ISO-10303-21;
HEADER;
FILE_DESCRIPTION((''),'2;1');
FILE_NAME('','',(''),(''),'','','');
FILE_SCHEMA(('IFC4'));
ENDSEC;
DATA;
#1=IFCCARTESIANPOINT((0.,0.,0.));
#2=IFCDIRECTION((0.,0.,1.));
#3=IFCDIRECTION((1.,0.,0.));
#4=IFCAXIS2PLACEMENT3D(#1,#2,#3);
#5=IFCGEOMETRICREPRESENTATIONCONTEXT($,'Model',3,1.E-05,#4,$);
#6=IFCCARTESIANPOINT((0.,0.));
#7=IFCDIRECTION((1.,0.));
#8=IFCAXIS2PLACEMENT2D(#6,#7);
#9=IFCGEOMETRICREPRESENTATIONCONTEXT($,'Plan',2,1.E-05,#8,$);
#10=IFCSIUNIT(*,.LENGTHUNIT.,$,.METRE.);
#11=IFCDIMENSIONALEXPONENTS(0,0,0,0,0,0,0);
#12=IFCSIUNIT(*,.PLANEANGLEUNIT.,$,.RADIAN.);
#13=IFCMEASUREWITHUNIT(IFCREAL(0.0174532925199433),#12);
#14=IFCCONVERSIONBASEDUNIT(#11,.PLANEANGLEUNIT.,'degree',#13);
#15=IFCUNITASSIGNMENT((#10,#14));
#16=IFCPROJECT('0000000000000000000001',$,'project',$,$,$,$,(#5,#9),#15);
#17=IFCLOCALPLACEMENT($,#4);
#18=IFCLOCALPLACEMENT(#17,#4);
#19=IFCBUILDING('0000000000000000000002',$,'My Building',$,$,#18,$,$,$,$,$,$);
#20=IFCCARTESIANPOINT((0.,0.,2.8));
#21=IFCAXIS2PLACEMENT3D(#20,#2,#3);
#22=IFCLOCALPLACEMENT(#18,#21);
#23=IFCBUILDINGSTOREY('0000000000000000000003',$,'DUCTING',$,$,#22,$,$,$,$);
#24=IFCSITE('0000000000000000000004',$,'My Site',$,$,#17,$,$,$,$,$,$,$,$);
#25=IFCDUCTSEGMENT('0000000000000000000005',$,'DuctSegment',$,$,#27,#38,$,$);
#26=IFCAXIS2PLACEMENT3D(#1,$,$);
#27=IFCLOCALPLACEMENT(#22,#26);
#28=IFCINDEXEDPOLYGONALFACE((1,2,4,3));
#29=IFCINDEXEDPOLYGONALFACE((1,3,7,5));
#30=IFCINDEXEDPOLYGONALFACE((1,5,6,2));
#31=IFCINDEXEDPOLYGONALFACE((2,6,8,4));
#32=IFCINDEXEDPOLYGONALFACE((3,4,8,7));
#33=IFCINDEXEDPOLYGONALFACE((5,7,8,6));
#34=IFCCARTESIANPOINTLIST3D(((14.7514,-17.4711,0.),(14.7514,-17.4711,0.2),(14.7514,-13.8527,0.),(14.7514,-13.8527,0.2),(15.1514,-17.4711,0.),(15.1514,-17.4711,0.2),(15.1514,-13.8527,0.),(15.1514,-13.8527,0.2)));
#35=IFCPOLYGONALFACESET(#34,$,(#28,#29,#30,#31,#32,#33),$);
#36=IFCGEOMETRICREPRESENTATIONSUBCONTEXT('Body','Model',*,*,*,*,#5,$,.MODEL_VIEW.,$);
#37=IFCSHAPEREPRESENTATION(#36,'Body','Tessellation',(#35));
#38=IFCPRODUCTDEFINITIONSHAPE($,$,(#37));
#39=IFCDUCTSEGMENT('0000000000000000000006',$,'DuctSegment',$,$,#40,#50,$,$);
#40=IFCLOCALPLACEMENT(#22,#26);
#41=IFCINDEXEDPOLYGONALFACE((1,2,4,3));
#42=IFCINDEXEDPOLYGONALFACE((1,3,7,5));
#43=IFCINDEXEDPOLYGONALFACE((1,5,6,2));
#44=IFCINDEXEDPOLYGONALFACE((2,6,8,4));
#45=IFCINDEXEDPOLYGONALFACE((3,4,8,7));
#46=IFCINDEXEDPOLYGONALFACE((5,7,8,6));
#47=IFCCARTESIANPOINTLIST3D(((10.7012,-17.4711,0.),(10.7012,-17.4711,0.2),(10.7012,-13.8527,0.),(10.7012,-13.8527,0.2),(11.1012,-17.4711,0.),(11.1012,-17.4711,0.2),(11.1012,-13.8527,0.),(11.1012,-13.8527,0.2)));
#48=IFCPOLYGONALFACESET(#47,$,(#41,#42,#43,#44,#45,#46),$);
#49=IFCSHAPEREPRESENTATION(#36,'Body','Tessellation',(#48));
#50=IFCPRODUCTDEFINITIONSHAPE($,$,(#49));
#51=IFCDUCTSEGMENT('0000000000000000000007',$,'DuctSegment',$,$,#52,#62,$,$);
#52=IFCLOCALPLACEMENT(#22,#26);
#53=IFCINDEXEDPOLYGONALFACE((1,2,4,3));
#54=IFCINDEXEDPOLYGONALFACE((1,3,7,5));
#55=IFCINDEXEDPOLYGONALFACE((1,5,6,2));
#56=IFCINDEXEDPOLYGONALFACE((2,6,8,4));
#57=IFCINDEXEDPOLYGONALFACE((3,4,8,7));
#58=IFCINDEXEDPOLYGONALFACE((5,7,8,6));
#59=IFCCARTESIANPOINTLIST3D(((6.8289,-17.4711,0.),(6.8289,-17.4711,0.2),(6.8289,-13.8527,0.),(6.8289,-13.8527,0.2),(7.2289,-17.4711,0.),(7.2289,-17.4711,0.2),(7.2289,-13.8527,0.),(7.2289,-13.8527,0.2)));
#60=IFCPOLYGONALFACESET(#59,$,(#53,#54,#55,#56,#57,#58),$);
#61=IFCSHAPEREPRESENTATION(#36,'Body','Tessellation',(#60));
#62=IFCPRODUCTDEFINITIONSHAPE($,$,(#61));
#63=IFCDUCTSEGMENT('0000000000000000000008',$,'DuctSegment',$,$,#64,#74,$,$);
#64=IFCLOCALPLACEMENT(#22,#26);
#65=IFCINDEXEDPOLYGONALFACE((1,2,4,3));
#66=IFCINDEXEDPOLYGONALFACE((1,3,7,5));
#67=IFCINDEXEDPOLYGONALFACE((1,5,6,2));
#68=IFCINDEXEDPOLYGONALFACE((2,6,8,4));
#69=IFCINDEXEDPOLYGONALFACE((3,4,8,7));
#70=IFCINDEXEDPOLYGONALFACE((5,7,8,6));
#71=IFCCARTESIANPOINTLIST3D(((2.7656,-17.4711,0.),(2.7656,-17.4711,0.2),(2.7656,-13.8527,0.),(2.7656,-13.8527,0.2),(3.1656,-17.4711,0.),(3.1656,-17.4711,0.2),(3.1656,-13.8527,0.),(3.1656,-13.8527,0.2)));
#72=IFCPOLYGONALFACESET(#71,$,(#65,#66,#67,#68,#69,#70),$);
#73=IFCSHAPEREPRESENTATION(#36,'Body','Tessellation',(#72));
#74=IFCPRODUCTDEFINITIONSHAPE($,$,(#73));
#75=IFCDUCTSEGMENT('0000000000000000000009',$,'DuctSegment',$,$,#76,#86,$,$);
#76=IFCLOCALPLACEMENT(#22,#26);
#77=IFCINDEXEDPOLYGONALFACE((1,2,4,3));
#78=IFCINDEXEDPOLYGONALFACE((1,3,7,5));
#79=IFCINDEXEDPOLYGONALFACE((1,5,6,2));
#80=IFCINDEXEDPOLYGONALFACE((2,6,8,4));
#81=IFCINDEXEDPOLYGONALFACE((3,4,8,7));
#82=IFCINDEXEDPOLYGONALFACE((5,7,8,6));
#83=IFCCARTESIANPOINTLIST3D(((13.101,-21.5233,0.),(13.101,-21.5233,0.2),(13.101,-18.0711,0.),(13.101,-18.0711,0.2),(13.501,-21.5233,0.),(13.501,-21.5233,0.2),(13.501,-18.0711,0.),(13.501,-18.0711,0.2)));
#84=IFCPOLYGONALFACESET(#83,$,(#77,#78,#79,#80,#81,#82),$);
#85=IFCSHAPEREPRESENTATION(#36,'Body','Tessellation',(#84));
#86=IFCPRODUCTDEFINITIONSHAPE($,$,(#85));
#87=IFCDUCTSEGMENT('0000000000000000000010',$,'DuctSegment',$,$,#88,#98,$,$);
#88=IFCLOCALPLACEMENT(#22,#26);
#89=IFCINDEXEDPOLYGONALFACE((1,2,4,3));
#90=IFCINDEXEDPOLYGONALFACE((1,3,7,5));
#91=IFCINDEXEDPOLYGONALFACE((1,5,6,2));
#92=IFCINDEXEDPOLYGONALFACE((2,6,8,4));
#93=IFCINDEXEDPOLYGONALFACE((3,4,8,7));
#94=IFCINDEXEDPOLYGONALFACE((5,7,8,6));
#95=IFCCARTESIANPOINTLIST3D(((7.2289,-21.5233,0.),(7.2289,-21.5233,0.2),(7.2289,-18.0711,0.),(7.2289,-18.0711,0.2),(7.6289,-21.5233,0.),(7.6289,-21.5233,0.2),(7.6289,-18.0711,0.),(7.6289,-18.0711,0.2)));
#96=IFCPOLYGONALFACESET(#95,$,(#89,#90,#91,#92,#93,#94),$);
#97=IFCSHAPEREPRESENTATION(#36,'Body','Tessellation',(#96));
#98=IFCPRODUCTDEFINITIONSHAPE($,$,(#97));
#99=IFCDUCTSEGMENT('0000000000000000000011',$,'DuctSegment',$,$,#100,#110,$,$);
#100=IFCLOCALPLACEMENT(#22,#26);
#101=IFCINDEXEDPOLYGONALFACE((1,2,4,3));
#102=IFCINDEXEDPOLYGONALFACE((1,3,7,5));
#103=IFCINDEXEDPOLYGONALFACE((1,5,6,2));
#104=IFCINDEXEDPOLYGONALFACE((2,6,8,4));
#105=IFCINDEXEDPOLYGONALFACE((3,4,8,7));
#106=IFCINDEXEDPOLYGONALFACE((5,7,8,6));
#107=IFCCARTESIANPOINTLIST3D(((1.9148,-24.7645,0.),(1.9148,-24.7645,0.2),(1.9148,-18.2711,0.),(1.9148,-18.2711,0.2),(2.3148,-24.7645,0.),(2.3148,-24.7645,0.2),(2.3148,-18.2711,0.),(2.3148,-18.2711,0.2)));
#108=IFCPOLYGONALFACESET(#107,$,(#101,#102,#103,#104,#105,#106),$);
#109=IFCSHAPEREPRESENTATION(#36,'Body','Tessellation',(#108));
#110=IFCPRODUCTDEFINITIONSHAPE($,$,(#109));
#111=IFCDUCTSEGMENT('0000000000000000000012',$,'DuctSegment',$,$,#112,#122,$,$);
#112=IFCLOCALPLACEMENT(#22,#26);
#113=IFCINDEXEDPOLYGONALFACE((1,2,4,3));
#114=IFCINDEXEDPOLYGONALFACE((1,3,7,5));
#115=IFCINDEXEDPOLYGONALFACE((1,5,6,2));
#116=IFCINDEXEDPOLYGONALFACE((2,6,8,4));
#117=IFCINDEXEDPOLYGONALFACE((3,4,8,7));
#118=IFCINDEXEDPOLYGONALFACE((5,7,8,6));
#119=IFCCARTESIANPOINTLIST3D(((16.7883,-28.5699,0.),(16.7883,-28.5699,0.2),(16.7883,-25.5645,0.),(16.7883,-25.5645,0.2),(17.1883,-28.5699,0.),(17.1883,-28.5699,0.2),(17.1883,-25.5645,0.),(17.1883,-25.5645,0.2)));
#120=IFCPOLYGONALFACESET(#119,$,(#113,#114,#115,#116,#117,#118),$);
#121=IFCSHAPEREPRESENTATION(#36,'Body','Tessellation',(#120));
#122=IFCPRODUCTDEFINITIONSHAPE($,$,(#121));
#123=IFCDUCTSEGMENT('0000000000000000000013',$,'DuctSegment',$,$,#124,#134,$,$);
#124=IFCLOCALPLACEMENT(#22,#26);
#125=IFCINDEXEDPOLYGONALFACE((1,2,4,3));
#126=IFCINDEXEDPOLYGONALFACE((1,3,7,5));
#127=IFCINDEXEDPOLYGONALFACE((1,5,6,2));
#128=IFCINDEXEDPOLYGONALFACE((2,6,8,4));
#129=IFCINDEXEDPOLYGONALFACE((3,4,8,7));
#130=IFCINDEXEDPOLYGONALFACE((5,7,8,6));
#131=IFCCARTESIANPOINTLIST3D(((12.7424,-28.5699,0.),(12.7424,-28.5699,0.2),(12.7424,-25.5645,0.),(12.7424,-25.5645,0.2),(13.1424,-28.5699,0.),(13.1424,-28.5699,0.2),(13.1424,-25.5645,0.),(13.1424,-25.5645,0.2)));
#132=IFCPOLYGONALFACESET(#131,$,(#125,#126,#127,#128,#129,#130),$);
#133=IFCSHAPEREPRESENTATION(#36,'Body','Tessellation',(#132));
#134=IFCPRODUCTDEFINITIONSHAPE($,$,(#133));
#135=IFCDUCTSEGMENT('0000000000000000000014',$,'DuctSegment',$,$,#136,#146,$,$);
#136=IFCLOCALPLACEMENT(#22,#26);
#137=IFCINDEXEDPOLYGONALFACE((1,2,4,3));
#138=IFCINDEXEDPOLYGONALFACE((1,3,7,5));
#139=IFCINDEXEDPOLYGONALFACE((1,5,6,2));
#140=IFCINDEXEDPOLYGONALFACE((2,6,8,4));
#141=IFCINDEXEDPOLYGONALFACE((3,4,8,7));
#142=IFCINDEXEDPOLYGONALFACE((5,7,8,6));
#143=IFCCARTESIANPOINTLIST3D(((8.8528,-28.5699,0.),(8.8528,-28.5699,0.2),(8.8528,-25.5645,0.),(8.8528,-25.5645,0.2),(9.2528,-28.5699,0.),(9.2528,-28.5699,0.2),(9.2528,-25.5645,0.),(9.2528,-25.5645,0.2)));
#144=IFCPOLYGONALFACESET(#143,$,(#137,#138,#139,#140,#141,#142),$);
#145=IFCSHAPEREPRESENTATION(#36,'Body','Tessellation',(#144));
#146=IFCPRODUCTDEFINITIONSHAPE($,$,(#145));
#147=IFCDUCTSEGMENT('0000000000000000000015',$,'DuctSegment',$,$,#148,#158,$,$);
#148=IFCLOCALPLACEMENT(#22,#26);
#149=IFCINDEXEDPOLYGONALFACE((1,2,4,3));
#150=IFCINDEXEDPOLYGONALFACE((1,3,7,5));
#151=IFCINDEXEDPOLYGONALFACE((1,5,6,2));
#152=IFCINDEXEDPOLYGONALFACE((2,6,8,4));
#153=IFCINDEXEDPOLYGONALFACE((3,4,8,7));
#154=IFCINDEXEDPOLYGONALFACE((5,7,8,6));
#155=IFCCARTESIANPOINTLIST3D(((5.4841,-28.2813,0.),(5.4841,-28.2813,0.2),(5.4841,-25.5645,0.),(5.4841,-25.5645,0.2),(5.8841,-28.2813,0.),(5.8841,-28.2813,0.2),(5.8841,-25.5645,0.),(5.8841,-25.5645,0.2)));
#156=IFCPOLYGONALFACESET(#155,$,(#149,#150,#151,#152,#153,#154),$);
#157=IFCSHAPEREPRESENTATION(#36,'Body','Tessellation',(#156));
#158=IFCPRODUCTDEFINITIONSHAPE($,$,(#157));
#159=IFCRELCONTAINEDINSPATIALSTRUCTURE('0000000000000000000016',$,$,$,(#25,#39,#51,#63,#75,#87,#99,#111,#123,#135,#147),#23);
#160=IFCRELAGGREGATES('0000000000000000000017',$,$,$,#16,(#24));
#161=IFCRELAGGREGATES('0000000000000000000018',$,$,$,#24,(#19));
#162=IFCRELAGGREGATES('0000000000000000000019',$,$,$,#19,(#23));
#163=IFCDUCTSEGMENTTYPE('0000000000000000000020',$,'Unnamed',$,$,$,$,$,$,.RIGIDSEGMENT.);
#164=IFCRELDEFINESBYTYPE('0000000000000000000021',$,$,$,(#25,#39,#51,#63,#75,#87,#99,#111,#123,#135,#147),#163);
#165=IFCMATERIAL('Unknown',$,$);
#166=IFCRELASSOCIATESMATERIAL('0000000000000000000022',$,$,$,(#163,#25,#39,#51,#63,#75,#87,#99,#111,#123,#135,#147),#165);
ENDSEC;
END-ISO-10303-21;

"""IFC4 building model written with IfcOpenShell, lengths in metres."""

from ifc_helpers import new_model, entity, si_unit, converted_unit, frame, origin_with_axes, origin_2d_with_axis, place, context, subcontext, project, spatial, rectangle, extrude, material, material_profile, profile_set, profile_usage, type_object, element, save


model = new_model("IFC4")

# Units and contexts
model_context = context("Model", 3, precision=1e-05, world=origin_with_axes())
plan_context = context("Plan", 2, precision=1e-05, world=origin_2d_with_axis())
body_context = subcontext(model_context, "Body", "Model", "MODEL_VIEW")
ifc_project = project(units=[si_unit("LENGTHUNIT", "METRE"), converted_unit("PLANEANGLEUNIT", "degree", entity("IfcReal", 0.0174532925199433), si_unit("PLANEANGLEUNIT", "RADIAN"), dimensions=[0, 0, 0, 0, 0, 0, 0])], contexts=[model_context, plan_context])

# Site, building, storey
site_placement = place(None, origin_with_axes())
site = spatial("IfcSite", under=ifc_project, at=site_placement, Name="My Site")
building_placement = place(site_placement, origin_with_axes())
building = spatial("IfcBuilding", under=site, at=building_placement, Name="My Building")
storey_placement = place(building_placement, frame((0.0, 0.0, 2.8), z_axis=(0.0, 0.0, 1.0), x_axis=(1.0, 0.0, 0.0)))
storey = spatial("IfcBuildingStorey", under=building, at=storey_placement, Name="DUCTING")

# Duct segments
ifc_material = material(Name="Unknown")
ifc_material_profile_1 = material_profile(ifc_material, rectangle(XDim=0.4, YDim=0.2))
ifc_profile_set_1 = profile_set([ifc_material_profile_1])
ifc_profile_usage_1 = profile_usage(ifc_profile_set_1, cardinal=5)
duct_segment_type = type_object("IfcDuctSegmentType", Name="Unnamed", PredefinedType="RIGIDSEGMENT", material=ifc_profile_set_1)
duct_segment_1_placement = place(storey_placement, frame((14.9514, -17.4711, 0.1), z_axis=(0.0, 1.0, 0.0), x_axis=(-1.0, 0.0, 0.0)))
element("IfcDuctSegment", 1, at=duct_segment_1_placement, inside=storey, type_object=duct_segment_type, material=ifc_profile_usage_1, Name="DuctSegment", context=body_context, shape_type="SweptSolid", body=[
    extrude(rectangle(XDim=0.4, YDim=0.2), origin_with_axes(), (0.0, 0.0, 1.0), 3.6184),
])
ifc_profile_usage_2 = profile_usage(ifc_profile_set_1, cardinal=5)
duct_segment_2_placement = place(storey_placement, frame((10.9012, -17.4711, 0.1), z_axis=(0.0, 1.0, 0.0), x_axis=(-1.0, 0.0, 0.0)))
element("IfcDuctSegment", 2, at=duct_segment_2_placement, inside=storey, type_object=duct_segment_type, material=ifc_profile_usage_2, Name="DuctSegment", context=body_context, shape_type="SweptSolid", body=[
    extrude(rectangle(XDim=0.4, YDim=0.2), origin_with_axes(), (0.0, 0.0, 1.0), 3.6184),
])
ifc_profile_usage_3 = profile_usage(ifc_profile_set_1, cardinal=5)
duct_segment_3_placement = place(storey_placement, frame((7.0289, -17.4711, 0.1), z_axis=(0.0, 1.0, 0.0), x_axis=(-1.0, 0.0, 0.0)))
element("IfcDuctSegment", 3, at=duct_segment_3_placement, inside=storey, type_object=duct_segment_type, material=ifc_profile_usage_3, Name="DuctSegment", context=body_context, shape_type="SweptSolid", body=[
    extrude(rectangle(XDim=0.4, YDim=0.2), origin_with_axes(), (0.0, 0.0, 1.0), 3.6184),
])
ifc_profile_usage_4 = profile_usage(ifc_profile_set_1, cardinal=5)
duct_segment_4_placement = place(storey_placement, frame((2.9656, -17.4711, 0.1), z_axis=(0.0, 1.0, 0.0), x_axis=(-1.0, 0.0, 0.0)))
element("IfcDuctSegment", 4, at=duct_segment_4_placement, inside=storey, type_object=duct_segment_type, material=ifc_profile_usage_4, Name="DuctSegment", context=body_context, shape_type="SweptSolid", body=[
    extrude(rectangle(XDim=0.4, YDim=0.2), origin_with_axes(), (0.0, 0.0, 1.0), 3.6184),
])
ifc_profile_usage_5 = profile_usage(ifc_profile_set_1, cardinal=5)
duct_segment_5_placement = place(storey_placement, frame((13.301, -18.0711, 0.1), z_axis=(0.0, -1.0, 0.0), x_axis=(1.0, 0.0, 0.0)))
element("IfcDuctSegment", 5, at=duct_segment_5_placement, inside=storey, type_object=duct_segment_type, material=ifc_profile_usage_5, Name="DuctSegment", context=body_context, shape_type="SweptSolid", body=[
    extrude(rectangle(XDim=0.4, YDim=0.2), origin_with_axes(), (0.0, 0.0, 1.0), 3.4522),
])
ifc_profile_usage_6 = profile_usage(ifc_profile_set_1, cardinal=5)
duct_segment_6_placement = place(storey_placement, frame((7.4289, -18.0711, 0.1), z_axis=(0.0, -1.0, 0.0), x_axis=(1.0, 0.0, 0.0)))
element("IfcDuctSegment", 6, at=duct_segment_6_placement, inside=storey, type_object=duct_segment_type, material=ifc_profile_usage_6, Name="DuctSegment", context=body_context, shape_type="SweptSolid", body=[
    extrude(rectangle(XDim=0.4, YDim=0.2), origin_with_axes(), (0.0, 0.0, 1.0), 3.4522),
])
ifc_profile_usage_7 = profile_usage(ifc_profile_set_1, cardinal=5)
duct_segment_7_placement = place(storey_placement, frame((2.1148, -18.2711, 0.1), z_axis=(0.0, -1.0, -0.000001), x_axis=(1.0, 0.0, 0.0)))
element("IfcDuctSegment", 7, at=duct_segment_7_placement, inside=storey, type_object=duct_segment_type, material=ifc_profile_usage_7, Name="DuctSegment", context=body_context, shape_type="SweptSolid", body=[
    extrude(rectangle(XDim=0.4, YDim=0.2), origin_with_axes(), (0.0, 0.0, 1.0), 6.4934),
])
ifc_profile_usage_8 = profile_usage(ifc_profile_set_1, cardinal=5)
duct_segment_8_placement = place(storey_placement, frame((16.9883, -28.5699, 0.1), z_axis=(0.0, 1.0, 0.0), x_axis=(-1.0, 0.0, 0.0)))
element("IfcDuctSegment", 8, at=duct_segment_8_placement, inside=storey, type_object=duct_segment_type, material=ifc_profile_usage_8, Name="DuctSegment", context=body_context, shape_type="SweptSolid", body=[
    extrude(rectangle(XDim=0.4, YDim=0.2), origin_with_axes(), (0.0, 0.0, 1.0), 3.0055),
])
ifc_profile_usage_9 = profile_usage(ifc_profile_set_1, cardinal=5)
duct_segment_9_placement = place(storey_placement, frame((12.9424, -28.5699, 0.1), z_axis=(0.0, 1.0, 0.0), x_axis=(-1.0, 0.0, 0.0)))
element("IfcDuctSegment", 9, at=duct_segment_9_placement, inside=storey, type_object=duct_segment_type, material=ifc_profile_usage_9, Name="DuctSegment", context=body_context, shape_type="SweptSolid", body=[
    extrude(rectangle(XDim=0.4, YDim=0.2), origin_with_axes(), (0.0, 0.0, 1.0), 3.0055),
])
ifc_profile_usage_10 = profile_usage(ifc_profile_set_1, cardinal=5)
duct_segment_10_placement = place(storey_placement, frame((9.0528, -28.5699, 0.1), z_axis=(0.0, 1.0, 0.0), x_axis=(-1.0, 0.0, 0.0)))
element("IfcDuctSegment", 10, at=duct_segment_10_placement, inside=storey, type_object=duct_segment_type, material=ifc_profile_usage_10, Name="DuctSegment", context=body_context, shape_type="SweptSolid", body=[
    extrude(rectangle(XDim=0.4, YDim=0.2), origin_with_axes(), (0.0, 0.0, 1.0), 3.0055),
])
ifc_profile_usage_11 = profile_usage(ifc_profile_set_1, cardinal=5)
duct_segment_11_placement = place(storey_placement, frame((5.6841, -28.2813, 0.1), z_axis=(0.0, 1.0, 0.0), x_axis=(-1.0, 0.0, 0.0)))
element("IfcDuctSegment", 11, at=duct_segment_11_placement, inside=storey, type_object=duct_segment_type, material=ifc_profile_usage_11, Name="DuctSegment", context=body_context, shape_type="SweptSolid", body=[
    extrude(rectangle(XDim=0.4, YDim=0.2), origin_with_axes(), (0.0, 0.0, 1.0), 2.7169),
])

save(model, "model.ifc")
